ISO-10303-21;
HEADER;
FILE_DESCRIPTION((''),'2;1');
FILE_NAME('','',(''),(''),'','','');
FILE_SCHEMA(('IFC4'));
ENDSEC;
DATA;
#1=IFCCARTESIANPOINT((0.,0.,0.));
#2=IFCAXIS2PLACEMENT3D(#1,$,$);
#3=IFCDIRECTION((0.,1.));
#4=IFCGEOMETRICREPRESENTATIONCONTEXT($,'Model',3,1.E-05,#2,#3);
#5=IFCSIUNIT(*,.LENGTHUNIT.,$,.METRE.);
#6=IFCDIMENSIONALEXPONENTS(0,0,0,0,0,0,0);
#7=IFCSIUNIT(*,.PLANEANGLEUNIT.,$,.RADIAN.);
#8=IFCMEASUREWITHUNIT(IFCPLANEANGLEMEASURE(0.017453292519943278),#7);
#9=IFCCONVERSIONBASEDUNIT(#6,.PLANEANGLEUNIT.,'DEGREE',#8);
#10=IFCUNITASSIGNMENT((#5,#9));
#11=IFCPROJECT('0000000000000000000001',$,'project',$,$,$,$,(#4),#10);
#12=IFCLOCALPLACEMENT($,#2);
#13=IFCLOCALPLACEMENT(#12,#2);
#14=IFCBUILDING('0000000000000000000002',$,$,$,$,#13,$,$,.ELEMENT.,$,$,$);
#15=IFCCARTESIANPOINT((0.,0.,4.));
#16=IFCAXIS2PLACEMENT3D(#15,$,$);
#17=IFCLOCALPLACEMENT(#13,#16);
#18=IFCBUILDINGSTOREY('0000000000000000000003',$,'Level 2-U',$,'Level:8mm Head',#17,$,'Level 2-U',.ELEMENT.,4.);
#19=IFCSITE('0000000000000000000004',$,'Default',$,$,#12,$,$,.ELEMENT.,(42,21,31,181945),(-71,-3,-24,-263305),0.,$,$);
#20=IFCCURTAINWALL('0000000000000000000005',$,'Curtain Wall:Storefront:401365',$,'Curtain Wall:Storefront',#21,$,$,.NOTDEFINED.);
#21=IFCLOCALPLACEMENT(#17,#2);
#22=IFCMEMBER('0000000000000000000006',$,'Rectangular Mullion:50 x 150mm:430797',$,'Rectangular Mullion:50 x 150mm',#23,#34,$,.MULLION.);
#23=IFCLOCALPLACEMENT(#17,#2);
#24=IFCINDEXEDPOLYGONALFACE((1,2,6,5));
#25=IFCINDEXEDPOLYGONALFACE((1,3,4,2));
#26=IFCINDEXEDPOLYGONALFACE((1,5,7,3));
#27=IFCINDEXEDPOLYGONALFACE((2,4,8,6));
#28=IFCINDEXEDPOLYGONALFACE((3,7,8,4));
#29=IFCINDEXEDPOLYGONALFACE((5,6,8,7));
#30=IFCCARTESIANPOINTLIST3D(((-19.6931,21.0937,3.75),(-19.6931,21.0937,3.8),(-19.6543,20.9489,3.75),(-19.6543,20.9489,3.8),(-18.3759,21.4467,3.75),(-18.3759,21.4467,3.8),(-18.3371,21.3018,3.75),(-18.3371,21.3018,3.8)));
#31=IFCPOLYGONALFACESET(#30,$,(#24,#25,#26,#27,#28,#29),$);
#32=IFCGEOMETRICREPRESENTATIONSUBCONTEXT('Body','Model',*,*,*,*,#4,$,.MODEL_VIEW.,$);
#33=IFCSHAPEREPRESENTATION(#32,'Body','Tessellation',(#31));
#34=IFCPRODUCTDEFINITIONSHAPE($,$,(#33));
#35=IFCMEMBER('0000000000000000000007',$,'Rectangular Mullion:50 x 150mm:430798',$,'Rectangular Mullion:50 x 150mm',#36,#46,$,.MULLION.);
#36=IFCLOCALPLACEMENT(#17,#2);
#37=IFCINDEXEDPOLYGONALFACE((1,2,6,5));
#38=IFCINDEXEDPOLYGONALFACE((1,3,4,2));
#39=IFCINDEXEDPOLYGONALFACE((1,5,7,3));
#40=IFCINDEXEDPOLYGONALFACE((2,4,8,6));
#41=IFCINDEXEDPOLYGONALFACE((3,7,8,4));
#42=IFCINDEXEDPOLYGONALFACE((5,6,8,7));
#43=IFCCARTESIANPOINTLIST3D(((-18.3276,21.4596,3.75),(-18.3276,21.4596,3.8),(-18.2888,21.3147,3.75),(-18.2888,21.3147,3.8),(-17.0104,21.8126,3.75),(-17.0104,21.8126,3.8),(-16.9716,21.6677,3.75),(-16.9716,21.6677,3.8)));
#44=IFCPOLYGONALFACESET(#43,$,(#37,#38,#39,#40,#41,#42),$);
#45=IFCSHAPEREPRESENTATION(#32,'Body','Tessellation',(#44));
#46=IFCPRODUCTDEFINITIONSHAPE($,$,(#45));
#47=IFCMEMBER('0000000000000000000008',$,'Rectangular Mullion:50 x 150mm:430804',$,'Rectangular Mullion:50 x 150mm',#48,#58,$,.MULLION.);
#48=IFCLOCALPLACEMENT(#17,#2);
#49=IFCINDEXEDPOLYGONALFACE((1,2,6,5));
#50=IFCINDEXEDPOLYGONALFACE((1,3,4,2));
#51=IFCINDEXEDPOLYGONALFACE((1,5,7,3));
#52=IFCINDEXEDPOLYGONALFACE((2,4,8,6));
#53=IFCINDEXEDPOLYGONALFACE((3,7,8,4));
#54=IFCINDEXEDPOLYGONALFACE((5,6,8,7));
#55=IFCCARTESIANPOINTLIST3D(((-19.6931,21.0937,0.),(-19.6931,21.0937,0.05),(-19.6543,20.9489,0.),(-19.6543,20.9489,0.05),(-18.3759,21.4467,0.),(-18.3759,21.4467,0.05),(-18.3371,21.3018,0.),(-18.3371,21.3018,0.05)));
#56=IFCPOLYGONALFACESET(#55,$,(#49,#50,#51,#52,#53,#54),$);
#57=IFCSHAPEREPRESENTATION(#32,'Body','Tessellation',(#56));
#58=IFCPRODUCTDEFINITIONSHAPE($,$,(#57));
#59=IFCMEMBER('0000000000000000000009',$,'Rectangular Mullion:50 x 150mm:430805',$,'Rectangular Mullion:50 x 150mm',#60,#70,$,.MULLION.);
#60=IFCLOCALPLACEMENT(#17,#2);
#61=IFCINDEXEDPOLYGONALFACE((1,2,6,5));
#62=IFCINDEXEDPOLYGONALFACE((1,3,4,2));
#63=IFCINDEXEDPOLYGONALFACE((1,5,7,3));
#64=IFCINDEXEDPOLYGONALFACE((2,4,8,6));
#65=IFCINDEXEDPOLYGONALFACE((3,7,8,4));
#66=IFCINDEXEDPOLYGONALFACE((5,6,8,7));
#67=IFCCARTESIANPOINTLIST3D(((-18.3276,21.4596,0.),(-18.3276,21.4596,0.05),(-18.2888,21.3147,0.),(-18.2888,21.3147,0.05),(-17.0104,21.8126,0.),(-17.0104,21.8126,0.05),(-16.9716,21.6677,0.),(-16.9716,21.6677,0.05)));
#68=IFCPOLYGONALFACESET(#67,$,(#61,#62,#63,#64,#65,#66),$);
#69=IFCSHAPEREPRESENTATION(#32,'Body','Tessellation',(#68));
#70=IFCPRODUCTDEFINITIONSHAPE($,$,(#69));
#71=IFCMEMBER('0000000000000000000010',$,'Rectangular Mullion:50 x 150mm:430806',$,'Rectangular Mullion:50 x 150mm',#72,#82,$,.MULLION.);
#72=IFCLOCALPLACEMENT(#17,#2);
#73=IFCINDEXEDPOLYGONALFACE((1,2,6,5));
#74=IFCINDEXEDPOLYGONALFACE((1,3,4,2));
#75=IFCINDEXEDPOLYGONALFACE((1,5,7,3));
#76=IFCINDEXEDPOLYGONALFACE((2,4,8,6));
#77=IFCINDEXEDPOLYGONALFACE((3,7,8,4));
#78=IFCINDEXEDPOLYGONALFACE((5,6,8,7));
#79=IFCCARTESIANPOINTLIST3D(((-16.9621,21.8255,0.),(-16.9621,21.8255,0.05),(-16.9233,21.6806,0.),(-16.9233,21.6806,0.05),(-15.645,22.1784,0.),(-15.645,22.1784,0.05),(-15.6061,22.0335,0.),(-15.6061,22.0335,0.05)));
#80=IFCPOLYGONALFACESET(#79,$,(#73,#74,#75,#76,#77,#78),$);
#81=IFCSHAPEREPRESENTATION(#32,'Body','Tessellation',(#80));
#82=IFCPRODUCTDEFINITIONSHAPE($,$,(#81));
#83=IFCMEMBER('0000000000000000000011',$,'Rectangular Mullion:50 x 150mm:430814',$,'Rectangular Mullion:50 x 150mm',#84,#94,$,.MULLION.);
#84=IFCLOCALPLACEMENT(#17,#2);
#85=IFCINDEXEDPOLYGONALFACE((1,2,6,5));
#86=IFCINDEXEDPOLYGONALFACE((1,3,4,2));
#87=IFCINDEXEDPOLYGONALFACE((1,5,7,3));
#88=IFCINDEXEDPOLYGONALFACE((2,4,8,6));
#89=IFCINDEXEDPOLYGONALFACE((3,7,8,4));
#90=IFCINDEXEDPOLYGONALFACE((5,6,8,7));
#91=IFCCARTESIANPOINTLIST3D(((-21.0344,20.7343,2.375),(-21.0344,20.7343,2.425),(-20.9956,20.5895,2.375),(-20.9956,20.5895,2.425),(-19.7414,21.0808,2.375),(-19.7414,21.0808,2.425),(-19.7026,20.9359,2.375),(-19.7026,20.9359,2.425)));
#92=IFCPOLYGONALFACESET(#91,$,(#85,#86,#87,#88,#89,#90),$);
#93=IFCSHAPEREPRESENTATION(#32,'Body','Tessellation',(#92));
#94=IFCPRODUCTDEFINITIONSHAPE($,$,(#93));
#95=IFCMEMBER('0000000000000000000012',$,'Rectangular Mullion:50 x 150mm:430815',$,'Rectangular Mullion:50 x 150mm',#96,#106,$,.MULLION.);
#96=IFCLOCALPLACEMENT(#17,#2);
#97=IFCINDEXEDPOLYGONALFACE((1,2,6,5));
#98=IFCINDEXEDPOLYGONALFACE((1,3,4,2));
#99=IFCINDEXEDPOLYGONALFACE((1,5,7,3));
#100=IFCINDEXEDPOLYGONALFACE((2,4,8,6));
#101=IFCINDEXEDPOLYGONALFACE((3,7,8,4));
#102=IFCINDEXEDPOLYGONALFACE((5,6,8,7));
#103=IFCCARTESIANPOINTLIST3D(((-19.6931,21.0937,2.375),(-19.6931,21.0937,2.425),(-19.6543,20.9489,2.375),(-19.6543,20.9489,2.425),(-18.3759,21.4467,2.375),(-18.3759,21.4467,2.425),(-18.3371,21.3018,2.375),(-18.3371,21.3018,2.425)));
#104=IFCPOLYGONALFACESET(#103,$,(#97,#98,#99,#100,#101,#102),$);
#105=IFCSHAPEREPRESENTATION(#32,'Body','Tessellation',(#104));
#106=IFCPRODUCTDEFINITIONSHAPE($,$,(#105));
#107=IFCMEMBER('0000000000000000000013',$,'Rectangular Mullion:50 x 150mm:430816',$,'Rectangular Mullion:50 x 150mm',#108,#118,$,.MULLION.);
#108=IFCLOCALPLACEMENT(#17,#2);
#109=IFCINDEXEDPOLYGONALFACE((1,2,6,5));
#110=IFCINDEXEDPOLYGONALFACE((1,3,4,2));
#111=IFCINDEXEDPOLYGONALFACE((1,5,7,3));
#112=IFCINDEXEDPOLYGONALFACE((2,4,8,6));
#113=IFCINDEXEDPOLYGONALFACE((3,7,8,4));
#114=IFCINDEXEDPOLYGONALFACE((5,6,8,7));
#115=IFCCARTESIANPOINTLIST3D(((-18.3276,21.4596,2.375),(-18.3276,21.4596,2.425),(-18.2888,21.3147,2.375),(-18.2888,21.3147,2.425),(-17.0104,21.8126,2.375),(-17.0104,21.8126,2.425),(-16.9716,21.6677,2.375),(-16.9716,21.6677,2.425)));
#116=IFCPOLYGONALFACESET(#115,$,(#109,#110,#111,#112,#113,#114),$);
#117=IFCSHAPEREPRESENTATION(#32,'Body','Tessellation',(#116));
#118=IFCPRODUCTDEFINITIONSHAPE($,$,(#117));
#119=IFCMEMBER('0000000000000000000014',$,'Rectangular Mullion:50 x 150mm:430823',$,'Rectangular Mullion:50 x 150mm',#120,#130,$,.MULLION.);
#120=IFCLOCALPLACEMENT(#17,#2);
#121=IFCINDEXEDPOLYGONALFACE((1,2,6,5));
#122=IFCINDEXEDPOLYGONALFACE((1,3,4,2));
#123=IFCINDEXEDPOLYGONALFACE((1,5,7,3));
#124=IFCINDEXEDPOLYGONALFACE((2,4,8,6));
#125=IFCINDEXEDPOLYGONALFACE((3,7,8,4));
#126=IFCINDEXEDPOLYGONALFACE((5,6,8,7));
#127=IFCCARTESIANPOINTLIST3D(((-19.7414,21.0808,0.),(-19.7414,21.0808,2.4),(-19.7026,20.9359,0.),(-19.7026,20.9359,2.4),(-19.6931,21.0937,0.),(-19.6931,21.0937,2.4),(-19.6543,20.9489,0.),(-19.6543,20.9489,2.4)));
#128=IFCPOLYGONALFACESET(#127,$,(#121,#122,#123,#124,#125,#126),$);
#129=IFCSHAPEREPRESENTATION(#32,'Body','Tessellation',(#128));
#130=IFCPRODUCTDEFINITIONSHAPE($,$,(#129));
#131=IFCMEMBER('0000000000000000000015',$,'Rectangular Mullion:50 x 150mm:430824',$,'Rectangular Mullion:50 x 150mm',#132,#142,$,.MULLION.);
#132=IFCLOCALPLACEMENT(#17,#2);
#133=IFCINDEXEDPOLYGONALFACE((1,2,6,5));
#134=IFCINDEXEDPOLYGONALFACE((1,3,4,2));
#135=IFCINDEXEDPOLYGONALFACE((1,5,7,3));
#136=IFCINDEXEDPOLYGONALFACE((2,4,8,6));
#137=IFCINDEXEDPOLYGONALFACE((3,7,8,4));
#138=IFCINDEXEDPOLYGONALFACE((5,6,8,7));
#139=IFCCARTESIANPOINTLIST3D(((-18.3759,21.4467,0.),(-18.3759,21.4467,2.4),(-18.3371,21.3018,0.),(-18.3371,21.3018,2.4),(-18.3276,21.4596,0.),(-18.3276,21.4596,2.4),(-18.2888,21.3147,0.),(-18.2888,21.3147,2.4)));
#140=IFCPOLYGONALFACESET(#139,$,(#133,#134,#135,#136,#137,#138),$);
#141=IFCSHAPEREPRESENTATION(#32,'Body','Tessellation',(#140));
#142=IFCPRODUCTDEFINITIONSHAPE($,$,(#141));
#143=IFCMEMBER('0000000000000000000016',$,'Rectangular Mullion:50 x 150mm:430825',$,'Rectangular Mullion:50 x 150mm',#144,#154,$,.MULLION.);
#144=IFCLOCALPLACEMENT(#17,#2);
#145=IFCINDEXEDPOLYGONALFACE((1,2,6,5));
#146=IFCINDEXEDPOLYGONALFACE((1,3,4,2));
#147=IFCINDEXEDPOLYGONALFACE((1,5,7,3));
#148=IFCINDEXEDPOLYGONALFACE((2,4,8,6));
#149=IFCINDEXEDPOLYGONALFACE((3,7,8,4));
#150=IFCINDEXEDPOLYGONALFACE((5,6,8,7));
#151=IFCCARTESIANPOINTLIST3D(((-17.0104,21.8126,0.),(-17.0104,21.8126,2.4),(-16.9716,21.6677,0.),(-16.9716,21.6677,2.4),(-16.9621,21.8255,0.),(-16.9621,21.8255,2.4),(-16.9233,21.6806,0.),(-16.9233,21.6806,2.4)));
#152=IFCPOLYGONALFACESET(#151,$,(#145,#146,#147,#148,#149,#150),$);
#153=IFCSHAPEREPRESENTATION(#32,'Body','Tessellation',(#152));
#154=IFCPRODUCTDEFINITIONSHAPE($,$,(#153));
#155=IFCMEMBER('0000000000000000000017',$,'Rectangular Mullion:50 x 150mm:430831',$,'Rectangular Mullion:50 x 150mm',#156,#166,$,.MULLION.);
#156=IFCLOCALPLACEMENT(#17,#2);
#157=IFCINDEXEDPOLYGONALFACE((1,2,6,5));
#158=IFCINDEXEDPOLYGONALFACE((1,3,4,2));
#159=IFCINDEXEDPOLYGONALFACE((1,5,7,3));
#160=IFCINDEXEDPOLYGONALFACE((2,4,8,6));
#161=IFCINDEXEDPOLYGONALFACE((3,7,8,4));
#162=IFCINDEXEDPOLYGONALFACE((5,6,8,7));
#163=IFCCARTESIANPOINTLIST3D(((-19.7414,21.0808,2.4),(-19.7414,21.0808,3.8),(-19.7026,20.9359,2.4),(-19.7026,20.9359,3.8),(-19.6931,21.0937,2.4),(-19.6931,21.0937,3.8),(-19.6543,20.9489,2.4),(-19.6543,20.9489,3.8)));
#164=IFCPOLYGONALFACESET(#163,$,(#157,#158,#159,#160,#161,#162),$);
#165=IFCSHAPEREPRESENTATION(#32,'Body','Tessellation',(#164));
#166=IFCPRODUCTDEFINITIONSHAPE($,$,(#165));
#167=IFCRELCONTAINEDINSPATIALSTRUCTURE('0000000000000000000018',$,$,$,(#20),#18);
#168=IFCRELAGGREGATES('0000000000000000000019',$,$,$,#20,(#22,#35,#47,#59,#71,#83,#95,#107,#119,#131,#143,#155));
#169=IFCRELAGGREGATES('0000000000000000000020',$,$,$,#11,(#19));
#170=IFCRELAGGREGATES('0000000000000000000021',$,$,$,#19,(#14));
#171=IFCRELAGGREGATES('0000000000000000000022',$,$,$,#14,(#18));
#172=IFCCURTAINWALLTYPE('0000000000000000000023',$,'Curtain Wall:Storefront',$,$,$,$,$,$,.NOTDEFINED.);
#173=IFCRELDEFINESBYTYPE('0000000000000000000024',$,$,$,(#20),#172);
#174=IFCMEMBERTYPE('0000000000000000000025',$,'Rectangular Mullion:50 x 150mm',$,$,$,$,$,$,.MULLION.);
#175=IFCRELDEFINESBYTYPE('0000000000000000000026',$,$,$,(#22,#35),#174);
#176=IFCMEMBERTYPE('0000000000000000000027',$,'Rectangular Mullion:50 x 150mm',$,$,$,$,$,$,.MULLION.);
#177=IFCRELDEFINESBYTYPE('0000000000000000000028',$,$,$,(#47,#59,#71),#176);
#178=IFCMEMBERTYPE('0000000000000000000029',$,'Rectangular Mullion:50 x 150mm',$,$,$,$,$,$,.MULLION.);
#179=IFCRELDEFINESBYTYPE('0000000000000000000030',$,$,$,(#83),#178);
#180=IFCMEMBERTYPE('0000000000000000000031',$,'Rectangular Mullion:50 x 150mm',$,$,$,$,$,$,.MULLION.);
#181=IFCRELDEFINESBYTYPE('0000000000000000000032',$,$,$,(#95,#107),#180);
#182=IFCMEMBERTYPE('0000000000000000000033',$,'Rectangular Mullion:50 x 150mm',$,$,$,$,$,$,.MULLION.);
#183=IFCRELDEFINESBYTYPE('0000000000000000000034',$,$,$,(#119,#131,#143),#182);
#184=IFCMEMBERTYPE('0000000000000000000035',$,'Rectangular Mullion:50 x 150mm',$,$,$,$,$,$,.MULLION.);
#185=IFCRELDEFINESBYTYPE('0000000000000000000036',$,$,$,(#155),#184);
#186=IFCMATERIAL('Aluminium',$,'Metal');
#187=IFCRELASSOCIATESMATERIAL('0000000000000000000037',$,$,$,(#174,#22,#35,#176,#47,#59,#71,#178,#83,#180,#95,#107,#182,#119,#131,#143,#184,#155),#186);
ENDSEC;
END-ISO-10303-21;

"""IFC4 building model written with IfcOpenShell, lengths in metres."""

from ifc_helpers import new_model, entity, si_unit, converted_unit, direction, frame, origin, place, context, subcontext, project, spatial, indexed_curve, outline, extrude, source, transform, mapped, material, type_object, type_shapes, element, aggregate, save


model = new_model("IFC4")

# Units and contexts
model_context = context("Model", 3, precision=1e-05, world=origin(), true_north=direction((0.0, 1.0)))
body_context = subcontext(model_context, "Body", "Model", "MODEL_VIEW")
ifc_project = project(units=[si_unit("LENGTHUNIT", "METRE"), converted_unit("PLANEANGLEUNIT", "DEGREE", entity("IfcPlaneAngleMeasure", 0.017453292519943278), si_unit("PLANEANGLEUNIT", "RADIAN"), dimensions=[0, 0, 0, 0, 0, 0, 0])], contexts=[model_context])

# Site, building, storey
site_placement = place(None, origin())
site = spatial("IfcSite", under=ifc_project, at=site_placement, Name="Default", CompositionType="ELEMENT", RefLatitude=(42, 21, 31, 181945), RefLongitude=(-71, -3, -24, -263305), RefElevation=0.0)
building_placement = place(site_placement, origin())
building = spatial("IfcBuilding", under=site, at=building_placement, CompositionType="ELEMENT")
storey_placement = place(building_placement, frame((0.0, 0.0, 4.0)))
storey = spatial("IfcBuildingStorey", under=building, at=storey_placement, Name="Level 2-U", ObjectType="Level:8mm Head", LongName="Level 2-U", CompositionType="ELEMENT", Elevation=4.0)

# Curtain wall, members
curtain_wall_type = type_object("IfcCurtainWallType", Name="Curtain Wall:Storefront", PredefinedType="NOTDEFINED")
curtain_wall_placement = place(storey_placement, frame((0.0, 0.0, -4.0)))
curtain_wall = element("IfcCurtainWall", 1, at=curtain_wall_placement, inside=storey, type_object=curtain_wall_type, Name="Curtain Wall:Storefront:401365", ObjectType="Curtain Wall:Storefront", PredefinedType="NOTDEFINED")
ifc_material_1 = material(Name="Aluminium", Category="Metal")
member_type_1 = type_object("IfcMemberType", Name="Rectangular Mullion:50 x 150mm", PredefinedType="MULLION", material=ifc_material_1)
shared_shape_1 = source(origin(), body_context, "Body", "SweptSolid", [
    extrude(outline(indexed_curve([(-0.025, -0.075), (0.025, -0.075), (0.025, 0.075), (-0.025, 0.075), (-0.025, -0.075)], self_intersect=False)), frame((-0.025, 0.0, -1.3636), z_axis=(0.0, 0.0, 1.0), x_axis=(-1.0, 0.0, 0.0)), (0.0, 0.0, 1.0), 1.3636),
])
type_shapes(member_type_1, [shared_shape_1])
member_1_placement = place(curtain_wall_placement, frame((-18.3565, 21.3742, 7.8), z_axis=(0.965926, 0.258819, 0.0), x_axis=(0.0, 0.0, 1.0)))
member_1 = element("IfcMember", 2, at=member_1_placement, type_object=member_type_1, material=ifc_material_1, Name="Rectangular Mullion:50 x 150mm:430797", ObjectType="Rectangular Mullion:50 x 150mm", PredefinedType="MULLION", context=body_context, shape_type="MappedRepresentation", body=[
    mapped(shared_shape_1, transform((0.0, 0.0, 0.0), scale=1.0)),
])
member_2_placement = place(curtain_wall_placement, frame((-16.991, 21.7401, 7.8), z_axis=(0.965926, 0.258819, 0.0), x_axis=(0.0, 0.0, 1.0)))
member_2 = element("IfcMember", 3, at=member_2_placement, type_object=member_type_1, material=ifc_material_1, Name="Rectangular Mullion:50 x 150mm:430798", ObjectType="Rectangular Mullion:50 x 150mm", PredefinedType="MULLION", context=body_context, shape_type="MappedRepresentation", body=[
    mapped(shared_shape_1, transform((0.0, 0.0, 0.0), scale=1.0)),
])
member_type_2 = type_object("IfcMemberType", Name="Rectangular Mullion:50 x 150mm", PredefinedType="MULLION", material=ifc_material_1)
shared_shape_2 = source(origin(), body_context, "Body", "SweptSolid", [
    extrude(outline(indexed_curve([(-0.025, -0.075), (0.025, -0.075), (0.025, 0.075), (-0.025, 0.075), (-0.025, -0.075)], self_intersect=False)), frame((-0.025, 0.0, -1.3636), z_axis=(0.0, 0.0, 1.0), x_axis=(-1.0, 0.0, 0.0)), (0.0, 0.0, 1.0), 1.3636),
])
type_shapes(member_type_2, [shared_shape_2])
member_3_placement = place(curtain_wall_placement, frame((-19.6737, 21.0213, 4.0), z_axis=(-0.965926, -0.258819, 0.0), x_axis=(0.0, 0.0, -1.0)))
member_3 = element("IfcMember", 4, at=member_3_placement, type_object=member_type_2, material=ifc_material_1, Name="Rectangular Mullion:50 x 150mm:430804", ObjectType="Rectangular Mullion:50 x 150mm", PredefinedType="MULLION", context=body_context, shape_type="MappedRepresentation", body=[
    mapped(shared_shape_2, transform((0.0, 0.0, 0.0), scale=1.0)),
])
member_4_placement = place(curtain_wall_placement, frame((-18.3082, 21.3872, 4.0), z_axis=(-0.965926, -0.258819, 0.0), x_axis=(0.0, 0.0, -1.0)))
member_4 = element("IfcMember", 5, at=member_4_placement, type_object=member_type_2, material=ifc_material_1, Name="Rectangular Mullion:50 x 150mm:430805", ObjectType="Rectangular Mullion:50 x 150mm", PredefinedType="MULLION", context=body_context, shape_type="MappedRepresentation", body=[
    mapped(shared_shape_2, transform((0.0, 0.0, 0.0), scale=1.0)),
])
member_5_placement = place(curtain_wall_placement, frame((-16.9427, 21.7531, 4.0), z_axis=(-0.965926, -0.258819, 0.0), x_axis=(0.0, 0.0, -1.0)))
member_5 = element("IfcMember", 6, at=member_5_placement, type_object=member_type_2, material=ifc_material_1, Name="Rectangular Mullion:50 x 150mm:430806", ObjectType="Rectangular Mullion:50 x 150mm", PredefinedType="MULLION", context=body_context, shape_type="MappedRepresentation", body=[
    mapped(shared_shape_2, transform((0.0, 0.0, 0.0), scale=1.0)),
])
member_type_3 = type_object("IfcMemberType", Name="Rectangular Mullion:50 x 150mm", PredefinedType="MULLION", material=ifc_material_1)
shared_shape_3 = source(origin(), body_context, "Body", "SweptSolid", [
    extrude(outline(indexed_curve([(-0.025, -0.075), (0.025, -0.075), (0.025, 0.075), (-0.025, 0.075), (-0.025, -0.075)], self_intersect=False)), frame((0.0, 0.0, -1.3386), z_axis=(0.0, 0.0, 1.0), x_axis=(-1.0, 0.0, 0.0)), (0.0, 0.0, 1.0), 1.3386),
])
type_shapes(member_type_3, [shared_shape_3])
member_6_placement = place(curtain_wall_placement, frame((-19.722, 21.0084, 6.4), z_axis=(0.965926, 0.258819, 0.0), x_axis=(0.0, 0.0, 1.0)))
member_6 = element("IfcMember", 7, at=member_6_placement, type_object=member_type_3, material=ifc_material_1, Name="Rectangular Mullion:50 x 150mm:430814", ObjectType="Rectangular Mullion:50 x 150mm", PredefinedType="MULLION", context=body_context, shape_type="MappedRepresentation", body=[
    mapped(shared_shape_3, transform((0.0, 0.0, 0.0), scale=1.0)),
])
member_type_4 = type_object("IfcMemberType", Name="Rectangular Mullion:50 x 150mm", PredefinedType="MULLION", material=ifc_material_1)
shared_shape_4 = source(origin(), body_context, "Body", "SweptSolid", [
    extrude(outline(indexed_curve([(-0.025, -0.075), (0.025, -0.075), (0.025, 0.075), (-0.025, 0.075), (-0.025, -0.075)], self_intersect=False)), frame((0.0, 0.0, -1.3636), z_axis=(0.0, 0.0, 1.0), x_axis=(-1.0, 0.0, 0.0)), (0.0, 0.0, 1.0), 1.3636),
])
type_shapes(member_type_4, [shared_shape_4])
member_7_placement = place(curtain_wall_placement, frame((-18.3565, 21.3742, 6.4), z_axis=(0.965926, 0.258819, 0.0), x_axis=(0.0, 0.0, 1.0)))
member_7 = element("IfcMember", 8, at=member_7_placement, type_object=member_type_4, material=ifc_material_1, Name="Rectangular Mullion:50 x 150mm:430815", ObjectType="Rectangular Mullion:50 x 150mm", PredefinedType="MULLION", context=body_context, shape_type="MappedRepresentation", body=[
    mapped(shared_shape_4, transform((0.0, 0.0, 0.0), scale=1.0)),
])
member_8_placement = place(curtain_wall_placement, frame((-16.991, 21.7401, 6.4), z_axis=(0.965926, 0.258819, 0.0), x_axis=(0.0, 0.0, 1.0)))
member_8 = element("IfcMember", 9, at=member_8_placement, type_object=member_type_4, material=ifc_material_1, Name="Rectangular Mullion:50 x 150mm:430816", ObjectType="Rectangular Mullion:50 x 150mm", PredefinedType="MULLION", context=body_context, shape_type="MappedRepresentation", body=[
    mapped(shared_shape_4, transform((0.0, 0.0, 0.0), scale=1.0)),
])
member_type_5 = type_object("IfcMemberType", Name="Rectangular Mullion:50 x 150mm", PredefinedType="MULLION", material=ifc_material_1)
shared_shape_5 = source(origin(), body_context, "Body", "SweptSolid", [
    extrude(outline(indexed_curve([(-0.025, -0.075), (0.025, -0.075), (0.025, 0.075), (-0.025, 0.075), (-0.025, -0.075)], self_intersect=False)), frame((0.0, 0.0, -2.4), z_axis=(0.0, 0.0, 1.0), x_axis=(-1.0, 0.0, 0.0)), (0.0, 0.0, 1.0), 2.4),
])
type_shapes(member_type_5, [shared_shape_5])
member_9_placement = place(curtain_wall_placement, frame((-19.6978, 21.0148, 4.0), z_axis=(0.0, 0.0, -1.0), x_axis=(0.965926, 0.258819, 0.0)))
member_9 = element("IfcMember", 10, at=member_9_placement, type_object=member_type_5, material=ifc_material_1, Name="Rectangular Mullion:50 x 150mm:430823", ObjectType="Rectangular Mullion:50 x 150mm", PredefinedType="MULLION", context=body_context, shape_type="MappedRepresentation", body=[
    mapped(shared_shape_5, transform((0.0, 0.0, 0.0), scale=1.0)),
])
member_10_placement = place(curtain_wall_placement, frame((-18.3324, 21.3807, 4.0), z_axis=(0.0, 0.0, -1.0), x_axis=(0.965926, 0.258819, 0.0)))
member_10 = element("IfcMember", 11, at=member_10_placement, type_object=member_type_5, material=ifc_material_1, Name="Rectangular Mullion:50 x 150mm:430824", ObjectType="Rectangular Mullion:50 x 150mm", PredefinedType="MULLION", context=body_context, shape_type="MappedRepresentation", body=[
    mapped(shared_shape_5, transform((0.0, 0.0, 0.0), scale=1.0)),
])
member_11_placement = place(curtain_wall_placement, frame((-16.9669, 21.7466, 4.0), z_axis=(0.0, 0.0, -1.0), x_axis=(0.965926, 0.258819, 0.0)))
member_11 = element("IfcMember", 12, at=member_11_placement, type_object=member_type_5, material=ifc_material_1, Name="Rectangular Mullion:50 x 150mm:430825", ObjectType="Rectangular Mullion:50 x 150mm", PredefinedType="MULLION", context=body_context, shape_type="MappedRepresentation", body=[
    mapped(shared_shape_5, transform((0.0, 0.0, 0.0), scale=1.0)),
])
member_type_6 = type_object("IfcMemberType", Name="Rectangular Mullion:50 x 150mm", PredefinedType="MULLION", material=ifc_material_1)
shared_shape_6 = source(origin(), body_context, "Body", "SweptSolid", [
    extrude(outline(indexed_curve([(-0.025, -0.075), (0.025, -0.075), (0.025, 0.075), (-0.025, 0.075), (-0.025, -0.075)], self_intersect=False)), frame((0.0, 0.0, -1.4), z_axis=(0.0, 0.0, 1.0), x_axis=(-1.0, 0.0, 0.0)), (0.0, 0.0, 1.0), 1.4),
])
type_shapes(member_type_6, [shared_shape_6])
member_12_placement = place(curtain_wall_placement, frame((-19.6978, 21.0148, 6.4), z_axis=(0.0, 0.0, -1.0), x_axis=(0.965926, 0.258819, 0.0)))
member_12 = element("IfcMember", 13, at=member_12_placement, type_object=member_type_6, material=ifc_material_1, Name="Rectangular Mullion:50 x 150mm:430831", ObjectType="Rectangular Mullion:50 x 150mm", PredefinedType="MULLION", context=body_context, shape_type="MappedRepresentation", body=[
    mapped(shared_shape_6, transform((0.0, 0.0, 0.0), scale=1.0)),
])
aggregate(curtain_wall, [member_1, member_2, member_3, member_4, member_5, member_6, member_7, member_8, member_9, member_10, member_11, member_12])

save(model, "model.ifc")
